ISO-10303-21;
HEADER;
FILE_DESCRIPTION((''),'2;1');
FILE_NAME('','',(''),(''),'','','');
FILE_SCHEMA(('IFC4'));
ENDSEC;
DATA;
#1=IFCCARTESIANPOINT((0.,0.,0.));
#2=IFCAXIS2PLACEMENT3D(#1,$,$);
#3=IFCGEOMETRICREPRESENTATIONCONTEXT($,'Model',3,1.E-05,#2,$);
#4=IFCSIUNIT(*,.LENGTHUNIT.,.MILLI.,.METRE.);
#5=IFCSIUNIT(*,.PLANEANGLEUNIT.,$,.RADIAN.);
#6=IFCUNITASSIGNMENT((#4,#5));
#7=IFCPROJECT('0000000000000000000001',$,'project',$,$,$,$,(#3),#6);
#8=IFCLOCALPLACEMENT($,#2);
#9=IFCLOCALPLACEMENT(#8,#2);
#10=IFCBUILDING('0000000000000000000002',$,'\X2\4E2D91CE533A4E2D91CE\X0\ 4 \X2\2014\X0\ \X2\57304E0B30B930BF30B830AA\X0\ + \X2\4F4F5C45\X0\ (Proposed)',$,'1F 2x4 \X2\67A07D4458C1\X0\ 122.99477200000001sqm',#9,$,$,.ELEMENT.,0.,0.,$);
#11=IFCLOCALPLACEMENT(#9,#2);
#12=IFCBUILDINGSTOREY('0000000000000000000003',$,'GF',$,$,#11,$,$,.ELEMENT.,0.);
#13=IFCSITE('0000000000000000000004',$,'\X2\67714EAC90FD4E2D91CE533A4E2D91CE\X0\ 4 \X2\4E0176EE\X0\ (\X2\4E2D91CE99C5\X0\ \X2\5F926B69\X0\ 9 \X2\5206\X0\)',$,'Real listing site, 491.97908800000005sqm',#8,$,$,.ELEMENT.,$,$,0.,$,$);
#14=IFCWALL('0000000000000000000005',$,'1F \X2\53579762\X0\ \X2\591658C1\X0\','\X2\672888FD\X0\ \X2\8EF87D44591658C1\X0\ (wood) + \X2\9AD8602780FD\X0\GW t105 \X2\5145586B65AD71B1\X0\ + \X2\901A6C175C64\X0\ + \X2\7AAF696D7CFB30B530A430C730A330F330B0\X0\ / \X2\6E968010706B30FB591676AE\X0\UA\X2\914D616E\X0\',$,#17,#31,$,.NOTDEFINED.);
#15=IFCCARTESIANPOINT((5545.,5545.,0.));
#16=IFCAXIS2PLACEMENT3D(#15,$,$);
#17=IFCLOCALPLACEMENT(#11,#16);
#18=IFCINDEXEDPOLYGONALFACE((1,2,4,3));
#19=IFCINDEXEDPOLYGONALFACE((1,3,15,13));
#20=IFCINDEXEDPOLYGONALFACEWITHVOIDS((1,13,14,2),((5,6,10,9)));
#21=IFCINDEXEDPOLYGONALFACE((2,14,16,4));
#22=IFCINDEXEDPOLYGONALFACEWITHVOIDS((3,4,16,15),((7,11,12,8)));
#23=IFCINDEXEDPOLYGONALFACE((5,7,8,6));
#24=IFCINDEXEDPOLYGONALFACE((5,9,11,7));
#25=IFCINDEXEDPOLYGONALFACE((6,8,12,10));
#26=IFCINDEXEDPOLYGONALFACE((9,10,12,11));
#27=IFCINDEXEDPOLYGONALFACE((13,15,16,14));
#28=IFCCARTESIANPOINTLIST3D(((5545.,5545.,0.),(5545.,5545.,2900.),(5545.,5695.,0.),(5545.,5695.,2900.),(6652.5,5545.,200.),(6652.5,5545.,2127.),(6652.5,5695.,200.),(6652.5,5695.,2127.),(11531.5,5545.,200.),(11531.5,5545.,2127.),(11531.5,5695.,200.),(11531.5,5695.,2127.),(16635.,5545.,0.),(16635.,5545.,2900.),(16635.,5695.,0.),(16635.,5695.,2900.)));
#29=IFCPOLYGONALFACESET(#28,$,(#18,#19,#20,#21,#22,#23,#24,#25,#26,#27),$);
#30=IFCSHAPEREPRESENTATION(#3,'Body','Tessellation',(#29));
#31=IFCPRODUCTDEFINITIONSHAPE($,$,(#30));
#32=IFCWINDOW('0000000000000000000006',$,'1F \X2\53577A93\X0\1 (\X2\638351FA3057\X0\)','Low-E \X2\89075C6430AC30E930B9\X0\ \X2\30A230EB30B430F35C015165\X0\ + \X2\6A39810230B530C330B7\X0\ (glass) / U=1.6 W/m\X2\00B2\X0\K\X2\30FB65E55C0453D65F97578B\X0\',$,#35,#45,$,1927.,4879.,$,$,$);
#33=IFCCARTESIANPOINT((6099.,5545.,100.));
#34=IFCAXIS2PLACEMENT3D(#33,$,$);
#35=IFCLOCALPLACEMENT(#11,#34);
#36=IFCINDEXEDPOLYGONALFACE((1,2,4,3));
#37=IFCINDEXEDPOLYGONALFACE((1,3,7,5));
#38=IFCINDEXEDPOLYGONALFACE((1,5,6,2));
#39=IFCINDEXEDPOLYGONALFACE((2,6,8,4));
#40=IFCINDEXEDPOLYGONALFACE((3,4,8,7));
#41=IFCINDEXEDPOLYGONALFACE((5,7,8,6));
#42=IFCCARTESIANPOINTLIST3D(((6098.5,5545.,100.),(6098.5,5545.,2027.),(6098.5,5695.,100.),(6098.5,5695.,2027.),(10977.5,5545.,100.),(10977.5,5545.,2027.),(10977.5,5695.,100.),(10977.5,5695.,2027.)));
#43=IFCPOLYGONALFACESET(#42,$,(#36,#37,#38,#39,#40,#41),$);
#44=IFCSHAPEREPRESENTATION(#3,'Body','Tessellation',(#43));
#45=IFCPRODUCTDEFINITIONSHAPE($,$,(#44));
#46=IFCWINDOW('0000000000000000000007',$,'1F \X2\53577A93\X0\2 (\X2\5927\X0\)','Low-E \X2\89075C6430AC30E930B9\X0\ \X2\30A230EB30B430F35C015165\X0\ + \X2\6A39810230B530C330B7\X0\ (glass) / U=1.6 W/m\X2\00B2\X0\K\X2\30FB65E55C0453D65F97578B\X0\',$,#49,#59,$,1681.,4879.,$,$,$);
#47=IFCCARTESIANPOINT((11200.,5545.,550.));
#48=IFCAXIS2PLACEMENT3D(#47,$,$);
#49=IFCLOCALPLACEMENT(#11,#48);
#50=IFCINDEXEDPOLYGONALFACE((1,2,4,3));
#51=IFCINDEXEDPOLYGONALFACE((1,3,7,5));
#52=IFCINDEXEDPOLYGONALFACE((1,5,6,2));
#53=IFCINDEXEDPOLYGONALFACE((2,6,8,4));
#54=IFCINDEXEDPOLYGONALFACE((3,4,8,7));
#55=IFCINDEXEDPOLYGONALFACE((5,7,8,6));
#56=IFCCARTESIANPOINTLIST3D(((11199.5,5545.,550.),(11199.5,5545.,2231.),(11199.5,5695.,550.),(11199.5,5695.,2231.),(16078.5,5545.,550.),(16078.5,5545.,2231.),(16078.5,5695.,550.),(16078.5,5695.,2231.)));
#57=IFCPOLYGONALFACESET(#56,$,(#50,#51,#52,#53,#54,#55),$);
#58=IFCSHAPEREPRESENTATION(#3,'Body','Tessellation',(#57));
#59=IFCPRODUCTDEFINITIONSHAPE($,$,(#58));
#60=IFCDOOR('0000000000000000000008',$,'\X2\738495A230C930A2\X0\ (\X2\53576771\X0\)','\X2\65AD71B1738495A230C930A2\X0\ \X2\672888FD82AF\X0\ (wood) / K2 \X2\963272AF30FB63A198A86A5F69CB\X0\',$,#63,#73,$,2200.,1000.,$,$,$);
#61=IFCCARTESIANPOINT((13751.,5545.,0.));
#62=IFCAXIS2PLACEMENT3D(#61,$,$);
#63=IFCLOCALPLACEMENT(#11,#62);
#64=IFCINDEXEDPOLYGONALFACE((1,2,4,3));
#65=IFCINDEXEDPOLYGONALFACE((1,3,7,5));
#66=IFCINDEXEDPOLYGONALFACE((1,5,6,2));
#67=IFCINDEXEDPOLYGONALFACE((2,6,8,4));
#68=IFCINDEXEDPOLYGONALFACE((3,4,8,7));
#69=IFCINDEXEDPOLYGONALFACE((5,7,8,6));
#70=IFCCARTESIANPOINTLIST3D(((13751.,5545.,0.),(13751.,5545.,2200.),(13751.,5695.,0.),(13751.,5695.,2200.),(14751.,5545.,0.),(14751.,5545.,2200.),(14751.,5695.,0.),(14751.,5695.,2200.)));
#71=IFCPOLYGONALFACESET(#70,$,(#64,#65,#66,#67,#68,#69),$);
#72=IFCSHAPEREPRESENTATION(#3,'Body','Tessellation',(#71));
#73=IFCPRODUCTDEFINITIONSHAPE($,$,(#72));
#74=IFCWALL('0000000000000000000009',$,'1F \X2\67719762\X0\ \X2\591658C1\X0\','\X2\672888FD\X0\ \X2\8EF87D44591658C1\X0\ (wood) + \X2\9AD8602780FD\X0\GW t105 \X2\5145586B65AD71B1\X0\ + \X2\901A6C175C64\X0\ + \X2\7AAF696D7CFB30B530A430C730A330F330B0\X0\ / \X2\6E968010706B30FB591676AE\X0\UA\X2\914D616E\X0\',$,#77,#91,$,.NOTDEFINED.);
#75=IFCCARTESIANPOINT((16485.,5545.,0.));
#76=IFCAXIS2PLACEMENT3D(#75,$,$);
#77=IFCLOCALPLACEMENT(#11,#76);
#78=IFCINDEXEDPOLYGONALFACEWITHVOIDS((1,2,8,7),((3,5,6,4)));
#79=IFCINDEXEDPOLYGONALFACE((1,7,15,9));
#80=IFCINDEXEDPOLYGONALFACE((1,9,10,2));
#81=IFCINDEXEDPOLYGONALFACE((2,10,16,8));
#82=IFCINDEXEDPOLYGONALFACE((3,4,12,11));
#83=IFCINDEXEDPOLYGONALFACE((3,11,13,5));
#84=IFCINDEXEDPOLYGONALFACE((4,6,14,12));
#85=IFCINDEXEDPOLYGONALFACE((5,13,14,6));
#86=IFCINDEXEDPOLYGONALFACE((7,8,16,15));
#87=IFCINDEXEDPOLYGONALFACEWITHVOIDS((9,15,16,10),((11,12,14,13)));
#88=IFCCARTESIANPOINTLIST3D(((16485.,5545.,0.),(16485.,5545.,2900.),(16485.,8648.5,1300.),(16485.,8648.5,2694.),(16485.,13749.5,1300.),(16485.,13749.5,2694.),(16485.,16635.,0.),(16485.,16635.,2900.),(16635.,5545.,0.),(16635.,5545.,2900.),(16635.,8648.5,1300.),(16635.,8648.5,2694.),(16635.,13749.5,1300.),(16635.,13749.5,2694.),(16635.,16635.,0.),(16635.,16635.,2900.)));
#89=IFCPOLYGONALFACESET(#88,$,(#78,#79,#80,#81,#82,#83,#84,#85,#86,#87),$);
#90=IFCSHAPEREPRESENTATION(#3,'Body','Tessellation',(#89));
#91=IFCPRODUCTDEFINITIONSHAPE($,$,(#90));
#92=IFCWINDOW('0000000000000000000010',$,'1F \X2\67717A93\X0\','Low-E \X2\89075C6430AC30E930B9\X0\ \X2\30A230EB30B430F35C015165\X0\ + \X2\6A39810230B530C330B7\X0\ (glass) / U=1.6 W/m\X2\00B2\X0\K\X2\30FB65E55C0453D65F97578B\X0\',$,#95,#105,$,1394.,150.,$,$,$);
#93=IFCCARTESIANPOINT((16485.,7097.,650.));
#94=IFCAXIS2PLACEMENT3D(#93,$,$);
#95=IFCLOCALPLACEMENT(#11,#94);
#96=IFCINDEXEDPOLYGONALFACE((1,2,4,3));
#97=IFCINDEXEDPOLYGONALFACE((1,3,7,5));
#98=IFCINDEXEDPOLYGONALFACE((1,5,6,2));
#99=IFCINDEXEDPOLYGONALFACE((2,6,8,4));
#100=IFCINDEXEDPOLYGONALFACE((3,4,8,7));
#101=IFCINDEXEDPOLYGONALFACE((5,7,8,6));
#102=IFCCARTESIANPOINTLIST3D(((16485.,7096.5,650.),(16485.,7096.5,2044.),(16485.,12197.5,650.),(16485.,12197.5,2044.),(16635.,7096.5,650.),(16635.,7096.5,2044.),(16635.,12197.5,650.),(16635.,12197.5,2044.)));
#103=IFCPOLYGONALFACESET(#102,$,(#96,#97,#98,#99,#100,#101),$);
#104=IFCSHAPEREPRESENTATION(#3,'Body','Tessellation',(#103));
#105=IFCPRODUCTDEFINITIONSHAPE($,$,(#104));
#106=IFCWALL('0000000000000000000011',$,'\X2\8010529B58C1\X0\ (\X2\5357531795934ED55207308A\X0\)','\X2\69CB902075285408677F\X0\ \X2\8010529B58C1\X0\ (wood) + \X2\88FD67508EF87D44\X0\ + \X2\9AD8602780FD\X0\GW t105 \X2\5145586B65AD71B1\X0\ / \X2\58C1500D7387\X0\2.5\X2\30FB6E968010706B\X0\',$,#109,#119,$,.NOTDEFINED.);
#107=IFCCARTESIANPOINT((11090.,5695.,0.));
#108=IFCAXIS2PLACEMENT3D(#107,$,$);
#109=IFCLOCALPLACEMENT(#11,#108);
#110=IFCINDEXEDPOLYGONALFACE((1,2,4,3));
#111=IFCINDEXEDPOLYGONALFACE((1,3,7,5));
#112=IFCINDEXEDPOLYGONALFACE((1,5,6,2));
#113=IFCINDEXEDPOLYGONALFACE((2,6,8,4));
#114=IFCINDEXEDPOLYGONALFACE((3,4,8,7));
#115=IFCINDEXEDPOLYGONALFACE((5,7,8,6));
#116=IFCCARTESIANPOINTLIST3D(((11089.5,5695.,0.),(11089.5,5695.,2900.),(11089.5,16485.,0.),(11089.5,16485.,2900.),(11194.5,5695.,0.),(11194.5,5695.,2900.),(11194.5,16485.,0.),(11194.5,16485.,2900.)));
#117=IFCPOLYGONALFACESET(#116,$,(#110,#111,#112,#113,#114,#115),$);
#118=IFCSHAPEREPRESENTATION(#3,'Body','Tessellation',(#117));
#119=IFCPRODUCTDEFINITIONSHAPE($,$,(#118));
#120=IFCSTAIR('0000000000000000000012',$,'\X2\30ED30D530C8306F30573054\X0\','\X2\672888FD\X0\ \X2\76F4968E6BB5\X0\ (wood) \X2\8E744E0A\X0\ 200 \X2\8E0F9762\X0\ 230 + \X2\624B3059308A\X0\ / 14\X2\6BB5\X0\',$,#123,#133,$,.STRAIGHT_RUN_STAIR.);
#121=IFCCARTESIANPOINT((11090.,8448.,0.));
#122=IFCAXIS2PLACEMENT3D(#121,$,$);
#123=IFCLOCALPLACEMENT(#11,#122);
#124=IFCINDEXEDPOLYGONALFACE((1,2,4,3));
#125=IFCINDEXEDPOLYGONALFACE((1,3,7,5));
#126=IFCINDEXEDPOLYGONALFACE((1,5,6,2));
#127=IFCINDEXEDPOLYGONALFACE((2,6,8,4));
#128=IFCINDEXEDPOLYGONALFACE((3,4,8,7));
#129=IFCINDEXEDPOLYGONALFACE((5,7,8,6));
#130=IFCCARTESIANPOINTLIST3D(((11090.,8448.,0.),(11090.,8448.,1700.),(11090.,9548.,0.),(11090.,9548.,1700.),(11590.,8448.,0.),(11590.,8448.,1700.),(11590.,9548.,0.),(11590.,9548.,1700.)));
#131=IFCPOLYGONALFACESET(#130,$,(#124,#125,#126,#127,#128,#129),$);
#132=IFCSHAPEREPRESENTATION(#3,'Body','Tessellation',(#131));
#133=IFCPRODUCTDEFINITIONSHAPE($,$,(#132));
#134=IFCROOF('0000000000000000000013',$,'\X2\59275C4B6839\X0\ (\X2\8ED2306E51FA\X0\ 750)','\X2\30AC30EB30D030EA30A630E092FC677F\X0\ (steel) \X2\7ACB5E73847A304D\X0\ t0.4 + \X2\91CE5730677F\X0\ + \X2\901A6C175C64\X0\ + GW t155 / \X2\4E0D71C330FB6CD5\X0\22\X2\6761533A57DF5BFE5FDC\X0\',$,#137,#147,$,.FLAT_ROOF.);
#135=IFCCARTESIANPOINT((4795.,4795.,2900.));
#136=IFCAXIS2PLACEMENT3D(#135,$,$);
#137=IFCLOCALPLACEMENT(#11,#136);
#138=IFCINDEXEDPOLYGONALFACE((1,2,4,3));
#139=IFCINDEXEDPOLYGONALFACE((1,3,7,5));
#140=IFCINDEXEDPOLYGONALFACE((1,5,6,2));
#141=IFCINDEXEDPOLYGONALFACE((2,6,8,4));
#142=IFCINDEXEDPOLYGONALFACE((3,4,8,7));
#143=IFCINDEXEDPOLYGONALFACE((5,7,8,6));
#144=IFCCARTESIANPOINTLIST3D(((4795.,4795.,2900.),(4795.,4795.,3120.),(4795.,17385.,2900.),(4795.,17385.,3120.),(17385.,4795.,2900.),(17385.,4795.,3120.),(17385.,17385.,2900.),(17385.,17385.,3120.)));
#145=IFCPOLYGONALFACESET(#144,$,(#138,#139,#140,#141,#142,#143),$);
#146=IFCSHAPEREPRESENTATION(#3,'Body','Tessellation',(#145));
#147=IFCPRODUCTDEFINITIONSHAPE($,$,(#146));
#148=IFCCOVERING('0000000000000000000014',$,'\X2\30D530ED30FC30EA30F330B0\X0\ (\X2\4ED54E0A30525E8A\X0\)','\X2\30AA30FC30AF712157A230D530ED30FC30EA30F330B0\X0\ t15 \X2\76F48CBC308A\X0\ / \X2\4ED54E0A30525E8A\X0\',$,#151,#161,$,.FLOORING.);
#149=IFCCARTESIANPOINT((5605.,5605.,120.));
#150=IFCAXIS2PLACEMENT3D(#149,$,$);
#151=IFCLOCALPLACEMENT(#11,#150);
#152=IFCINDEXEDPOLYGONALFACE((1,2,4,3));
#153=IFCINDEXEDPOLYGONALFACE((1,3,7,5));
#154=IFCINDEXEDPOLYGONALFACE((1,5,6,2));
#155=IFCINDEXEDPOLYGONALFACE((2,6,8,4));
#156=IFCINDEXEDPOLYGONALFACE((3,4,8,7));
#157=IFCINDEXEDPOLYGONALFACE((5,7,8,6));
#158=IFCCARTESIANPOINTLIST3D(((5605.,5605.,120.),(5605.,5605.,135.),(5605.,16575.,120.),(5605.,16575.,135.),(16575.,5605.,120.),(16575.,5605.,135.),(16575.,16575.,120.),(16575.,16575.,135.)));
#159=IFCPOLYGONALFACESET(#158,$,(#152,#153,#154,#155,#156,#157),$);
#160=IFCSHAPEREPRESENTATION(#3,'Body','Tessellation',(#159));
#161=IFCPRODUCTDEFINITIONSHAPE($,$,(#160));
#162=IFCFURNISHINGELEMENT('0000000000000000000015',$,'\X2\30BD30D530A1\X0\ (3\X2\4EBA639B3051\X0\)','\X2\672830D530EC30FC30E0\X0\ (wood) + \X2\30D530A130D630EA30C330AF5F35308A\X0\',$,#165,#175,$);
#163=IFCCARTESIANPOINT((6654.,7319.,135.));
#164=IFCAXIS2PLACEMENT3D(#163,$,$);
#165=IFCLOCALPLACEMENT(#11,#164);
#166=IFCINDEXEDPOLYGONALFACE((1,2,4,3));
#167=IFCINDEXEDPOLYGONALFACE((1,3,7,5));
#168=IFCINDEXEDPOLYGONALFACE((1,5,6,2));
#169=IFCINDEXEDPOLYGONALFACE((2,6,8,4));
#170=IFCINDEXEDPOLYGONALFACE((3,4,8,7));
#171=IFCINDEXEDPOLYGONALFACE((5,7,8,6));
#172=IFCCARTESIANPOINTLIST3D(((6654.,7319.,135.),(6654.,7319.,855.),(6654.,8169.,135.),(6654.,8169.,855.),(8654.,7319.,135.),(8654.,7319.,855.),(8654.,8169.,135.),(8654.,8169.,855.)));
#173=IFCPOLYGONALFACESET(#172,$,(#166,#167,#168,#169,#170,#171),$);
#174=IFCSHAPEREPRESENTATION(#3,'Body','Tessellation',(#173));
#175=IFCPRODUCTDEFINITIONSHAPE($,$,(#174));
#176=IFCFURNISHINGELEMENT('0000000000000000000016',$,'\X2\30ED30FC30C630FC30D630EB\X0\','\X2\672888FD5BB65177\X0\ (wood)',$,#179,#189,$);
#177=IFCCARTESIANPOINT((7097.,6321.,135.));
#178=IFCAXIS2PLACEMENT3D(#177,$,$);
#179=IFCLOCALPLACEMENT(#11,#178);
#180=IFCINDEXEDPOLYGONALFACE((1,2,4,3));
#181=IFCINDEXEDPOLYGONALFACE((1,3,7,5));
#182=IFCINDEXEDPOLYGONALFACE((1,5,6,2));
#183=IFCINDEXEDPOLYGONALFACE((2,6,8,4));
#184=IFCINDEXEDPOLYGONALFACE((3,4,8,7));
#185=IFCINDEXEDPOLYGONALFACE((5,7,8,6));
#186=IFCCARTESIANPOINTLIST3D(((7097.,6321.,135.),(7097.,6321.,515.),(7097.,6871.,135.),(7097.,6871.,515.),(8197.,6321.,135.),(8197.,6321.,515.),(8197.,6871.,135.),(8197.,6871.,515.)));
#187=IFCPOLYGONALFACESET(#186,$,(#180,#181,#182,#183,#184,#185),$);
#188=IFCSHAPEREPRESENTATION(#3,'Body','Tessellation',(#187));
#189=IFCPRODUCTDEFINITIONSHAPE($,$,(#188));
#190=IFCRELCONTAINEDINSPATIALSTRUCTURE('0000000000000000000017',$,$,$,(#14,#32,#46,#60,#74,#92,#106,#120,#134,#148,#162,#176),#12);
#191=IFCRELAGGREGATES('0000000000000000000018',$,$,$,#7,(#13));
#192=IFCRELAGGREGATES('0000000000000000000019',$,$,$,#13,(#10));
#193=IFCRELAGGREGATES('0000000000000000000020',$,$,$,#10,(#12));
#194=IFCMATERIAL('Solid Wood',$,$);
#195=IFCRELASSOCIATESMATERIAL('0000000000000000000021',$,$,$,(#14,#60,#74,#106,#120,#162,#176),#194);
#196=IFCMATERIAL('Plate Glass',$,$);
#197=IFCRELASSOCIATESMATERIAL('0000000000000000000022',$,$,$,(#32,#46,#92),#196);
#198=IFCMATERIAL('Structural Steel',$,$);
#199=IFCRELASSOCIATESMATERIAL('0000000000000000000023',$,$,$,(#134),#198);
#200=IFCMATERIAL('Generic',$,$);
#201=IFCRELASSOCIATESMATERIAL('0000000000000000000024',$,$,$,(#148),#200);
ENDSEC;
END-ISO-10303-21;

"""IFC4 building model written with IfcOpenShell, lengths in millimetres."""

from ifc_helpers import new_model, si_unit, frame, frame_2d, origin, place, context, project, spatial, rectangle, extrude, material, element, fill, save


model = new_model("IFC4")

# Units and contexts
model_context = context("Model", 3, precision=1e-05, world=origin())
ifc_project = project(units=[si_unit("LENGTHUNIT", "METRE", prefix="MILLI"), si_unit("PLANEANGLEUNIT", "RADIAN")], contexts=[model_context])

# Site, building, storey
site_placement = place(None, origin())
site = spatial("IfcSite", under=ifc_project, at=site_placement, Name="東京都中野区中野 4 丁目 (中野駅 徒歩 9 分)", ObjectType="Real listing site, 491.97908800000005sqm", CompositionType="ELEMENT", RefElevation=0.0)
building_placement = place(site_placement, origin())
building = spatial("IfcBuilding", under=site, at=building_placement, Name="中野区中野 4 — 地下スタジオ + 住居 (Proposed)", ObjectType="1F 2x4 枠組壁 122.99477200000001sqm", CompositionType="ELEMENT", ElevationOfRefHeight=0.0, ElevationOfTerrain=0.0)
storey_placement = place(building_placement, origin())
storey = spatial("IfcBuildingStorey", under=building, at=storey_placement, Name="GF", CompositionType="ELEMENT", Elevation=0.0)

# Shared definitions
ifc_material_1 = material(Name="Solid Wood")

# Wall, openings, windows, door
wall_1_placement = place(storey_placement, frame((5545.0, 5545.0, 0.0)))
wall_1 = element("IfcWall", 1, at=wall_1_placement, inside=storey, material=ifc_material_1, Name="1F 南面 外壁", Description="木製 軸組外壁 (wood) + 高性能GW t105 充填断熱 + 通気層 + 窯業系サイディング / 準耐火・外皮UA配慮", PredefinedType="NOTDEFINED", context=model_context, shape_type="SweptSolid", body=[
    extrude(rectangle(XDim=11090.0, YDim=150.0, at=frame_2d((5545.0, 75.0))), frame((5545.0, 5545.0, 0.0)), (0.0, 0.0, 1.0), 2900.0),
])
opening_1_placement = place(storey_placement, frame((6099.0, 5545.0, 100.0)))
opening_1 = element("IfcOpeningElement", 2, at=opening_1_placement, cuts=wall_1, PredefinedType="NOTDEFINED", context=model_context, shape_type="SweptSolid", body=[
    extrude(rectangle(XDim=4879.0, YDim=150.0, at=frame_2d((2439.0, 75.0))), frame((6099.0, 5545.0, 100.0)), (0.0, 0.0, 1.0), 1927.0),
])
opening_2_placement = place(storey_placement, frame((11200.0, 5545.0, 550.0)))
opening_2 = element("IfcOpeningElement", 3, at=opening_2_placement, cuts=wall_1, PredefinedType="NOTDEFINED", context=model_context, shape_type="SweptSolid", body=[
    extrude(rectangle(XDim=4879.0, YDim=150.0, at=frame_2d((2439.0, 75.0))), frame((11200.0, 5545.0, 550.0)), (0.0, 0.0, 1.0), 1681.0),
])
opening_3_placement = place(storey_placement, frame((13751.0, 5545.0, 0.0)))
opening_3 = element("IfcOpeningElement", 4, at=opening_3_placement, cuts=wall_1, PredefinedType="NOTDEFINED", context=model_context, shape_type="SweptSolid", body=[
    extrude(rectangle(XDim=1000.0, YDim=150.0, at=frame_2d((500.0, 75.0))), frame((13751.0, 5545.0, 0.0)), (0.0, 0.0, 1.0), 2200.0),
])
ifc_material_2 = material(Name="Plate Glass")
window_1_placement = place(storey_placement, frame((6099.0, 5545.0, 100.0)))
window_1 = element("IfcWindow", 5, at=window_1_placement, inside=storey, material=ifc_material_2, Name="1F 南窓1 (掃出し)", Description="Low-E 複層ガラス アルゴン封入 + 樹脂サッシ (glass) / U=1.6 W/m²K・日射取得型", OverallHeight=1927.0, OverallWidth=4879.0, context=model_context, shape_type="SweptSolid", body=[
    extrude(rectangle(XDim=4879.0, YDim=150.0, at=frame_2d((2439.0, 75.0))), frame((6099.0, 5545.0, 100.0)), (0.0, 0.0, 1.0), 1927.0),
])
fill(opening_1, window_1)
window_2_placement = place(storey_placement, frame((11200.0, 5545.0, 550.0)))
window_2 = element("IfcWindow", 6, at=window_2_placement, inside=storey, material=ifc_material_2, Name="1F 南窓2 (大)", Description="Low-E 複層ガラス アルゴン封入 + 樹脂サッシ (glass) / U=1.6 W/m²K・日射取得型", OverallHeight=1681.0, OverallWidth=4879.0, context=model_context, shape_type="SweptSolid", body=[
    extrude(rectangle(XDim=4879.0, YDim=150.0, at=frame_2d((2439.0, 75.0))), frame((11200.0, 5545.0, 550.0)), (0.0, 0.0, 1.0), 1681.0),
])
fill(opening_2, window_2)
door_placement = place(storey_placement, frame((13751.0, 5545.0, 0.0)))
door = element("IfcDoor", 7, at=door_placement, inside=storey, material=ifc_material_1, Name="玄関ドア (南東)", Description="断熱玄関ドア 木製芯 (wood) / K2 防犯・採風機構", OverallHeight=2200.0, OverallWidth=1000.0, context=model_context, shape_type="SweptSolid", body=[
    extrude(rectangle(XDim=1000.0, YDim=150.0, at=frame_2d((500.0, 75.0))), frame((13751.0, 5545.0, 0.0)), (0.0, 0.0, 1.0), 2200.0),
])
fill(opening_3, door)

# Wall, opening, window
wall_2_placement = place(storey_placement, frame((16485.0, 5545.0, 0.0)))
wall_2 = element("IfcWall", 8, at=wall_2_placement, inside=storey, material=ifc_material_1, Name="1F 東面 外壁", Description="木製 軸組外壁 (wood) + 高性能GW t105 充填断熱 + 通気層 + 窯業系サイディング / 準耐火・外皮UA配慮", PredefinedType="NOTDEFINED", context=model_context, shape_type="SweptSolid", body=[
    extrude(rectangle(XDim=150.0, YDim=11090.0, at=frame_2d((75.0, 5545.0))), frame((16485.0, 5545.0, 0.0)), (0.0, 0.0, 1.0), 2900.0),
])
opening_4_placement = place(storey_placement, frame((16485.0, 7097.0, 650.0)))
opening_4 = element("IfcOpeningElement", 9, at=opening_4_placement, cuts=wall_2, PredefinedType="NOTDEFINED", context=model_context, shape_type="SweptSolid", body=[
    extrude(rectangle(XDim=150.0, YDim=5101.0, at=frame_2d((75.0, 2550.0))), frame((16485.0, 7097.0, 650.0)), (0.0, 0.0, 1.0), 1394.0),
])
window_3_placement = place(storey_placement, frame((16485.0, 7097.0, 650.0)))
window_3 = element("IfcWindow", 10, at=window_3_placement, inside=storey, material=ifc_material_2, Name="1F 東窓", Description="Low-E 複層ガラス アルゴン封入 + 樹脂サッシ (glass) / U=1.6 W/m²K・日射取得型", OverallHeight=1394.0, OverallWidth=150.0, context=model_context, shape_type="SweptSolid", body=[
    extrude(rectangle(XDim=150.0, YDim=5101.0, at=frame_2d((75.0, 2550.0))), frame((16485.0, 7097.0, 650.0)), (0.0, 0.0, 1.0), 1394.0),
])
fill(opening_4, window_3)

# Wall
wall_3_placement = place(storey_placement, frame((11090.0, 5695.0, 0.0)))
element("IfcWall", 11, at=wall_3_placement, inside=storey, material=ifc_material_1, Name="耐力壁 (南北間仕切り)", Description="構造用合板 耐力壁 (wood) + 製材軸組 + 高性能GW t105 充填断熱 / 壁倍率2.5・準耐火", PredefinedType="NOTDEFINED", context=model_context, shape_type="SweptSolid", body=[
    extrude(rectangle(XDim=105.0, YDim=10790.0, at=frame_2d((52.0, 5395.0))), frame((11090.0, 5695.0, 0.0)), (0.0, 0.0, 1.0), 2900.0),
])

# Stair
stair_placement = place(storey_placement, frame((11090.0, 8448.0, 0.0)))
element("IfcStair", 12, at=stair_placement, inside=storey, material=ifc_material_1, Name="ロフトはしご", Description="木製 直階段 (wood) 蹴上 200 踏面 230 + 手すり / 14段", PredefinedType="STRAIGHT_RUN_STAIR", context=model_context, shape_type="SweptSolid", body=[
    extrude(rectangle(XDim=500.0, YDim=1100.0, at=frame_2d((250.0, 550.0))), frame((11090.0, 8448.0, 0.0)), (0.0, 0.0, 1.0), 1700.0),
])

# Roof
ifc_material_3 = material(Name="Structural Steel")
roof_placement = place(storey_placement, frame((4795.0, 4795.0, 2900.0)))
element("IfcRoof", 13, at=roof_placement, inside=storey, material=ifc_material_3, Name="大屋根 (軒の出 750)", Description="ガルバリウム鋼板 (steel) 立平葺き t0.4 + 野地板 + 通気層 + GW t155 / 不燃・法22条区域対応", PredefinedType="FLAT_ROOF", context=model_context, shape_type="SweptSolid", body=[
    extrude(rectangle(XDim=12590.0, YDim=12590.0, at=frame_2d((6295.0, 6295.0))), frame((4795.0, 4795.0, 2900.0)), (0.0, 0.0, 1.0), 220.0),
])

# Covering
ifc_material_4 = material(Name="Generic")
covering_placement = place(storey_placement, frame((5605.0, 5605.0, 120.0)))
element("IfcCovering", 14, at=covering_placement, inside=storey, material=ifc_material_4, Name="フローリング (仕上げ床)", Description="オーク無垢フローリング t15 直貼り / 仕上げ床", PredefinedType="FLOORING", context=model_context, shape_type="SweptSolid", body=[
    extrude(rectangle(XDim=10970.0, YDim=10970.0, at=frame_2d((5485.0, 5485.0))), frame((5605.0, 5605.0, 120.0)), (0.0, 0.0, 1.0), 15.0),
])

# Furnishing elements
furnishing_1_placement = place(storey_placement, frame((6654.0, 7319.0, 135.0)))
element("IfcFurnishingElement", 15, at=furnishing_1_placement, inside=storey, material=ifc_material_1, Name="ソファ (3人掛け)", Description="木フレーム (wood) + ファブリック張り", context=model_context, shape_type="SweptSolid", body=[
    extrude(rectangle(XDim=2000.0, YDim=850.0, at=frame_2d((1000.0, 425.0))), frame((6654.0, 7319.0, 135.0)), (0.0, 0.0, 1.0), 720.0),
])
furnishing_2_placement = place(storey_placement, frame((7097.0, 6321.0, 135.0)))
element("IfcFurnishingElement", 16, at=furnishing_2_placement, inside=storey, material=ifc_material_1, Name="ローテーブル", Description="木製家具 (wood)", context=model_context, shape_type="SweptSolid", body=[
    extrude(rectangle(XDim=1100.0, YDim=550.0, at=frame_2d((550.0, 275.0))), frame((7097.0, 6321.0, 135.0)), (0.0, 0.0, 1.0), 380.0),
])

save(model, "model.ifc")
